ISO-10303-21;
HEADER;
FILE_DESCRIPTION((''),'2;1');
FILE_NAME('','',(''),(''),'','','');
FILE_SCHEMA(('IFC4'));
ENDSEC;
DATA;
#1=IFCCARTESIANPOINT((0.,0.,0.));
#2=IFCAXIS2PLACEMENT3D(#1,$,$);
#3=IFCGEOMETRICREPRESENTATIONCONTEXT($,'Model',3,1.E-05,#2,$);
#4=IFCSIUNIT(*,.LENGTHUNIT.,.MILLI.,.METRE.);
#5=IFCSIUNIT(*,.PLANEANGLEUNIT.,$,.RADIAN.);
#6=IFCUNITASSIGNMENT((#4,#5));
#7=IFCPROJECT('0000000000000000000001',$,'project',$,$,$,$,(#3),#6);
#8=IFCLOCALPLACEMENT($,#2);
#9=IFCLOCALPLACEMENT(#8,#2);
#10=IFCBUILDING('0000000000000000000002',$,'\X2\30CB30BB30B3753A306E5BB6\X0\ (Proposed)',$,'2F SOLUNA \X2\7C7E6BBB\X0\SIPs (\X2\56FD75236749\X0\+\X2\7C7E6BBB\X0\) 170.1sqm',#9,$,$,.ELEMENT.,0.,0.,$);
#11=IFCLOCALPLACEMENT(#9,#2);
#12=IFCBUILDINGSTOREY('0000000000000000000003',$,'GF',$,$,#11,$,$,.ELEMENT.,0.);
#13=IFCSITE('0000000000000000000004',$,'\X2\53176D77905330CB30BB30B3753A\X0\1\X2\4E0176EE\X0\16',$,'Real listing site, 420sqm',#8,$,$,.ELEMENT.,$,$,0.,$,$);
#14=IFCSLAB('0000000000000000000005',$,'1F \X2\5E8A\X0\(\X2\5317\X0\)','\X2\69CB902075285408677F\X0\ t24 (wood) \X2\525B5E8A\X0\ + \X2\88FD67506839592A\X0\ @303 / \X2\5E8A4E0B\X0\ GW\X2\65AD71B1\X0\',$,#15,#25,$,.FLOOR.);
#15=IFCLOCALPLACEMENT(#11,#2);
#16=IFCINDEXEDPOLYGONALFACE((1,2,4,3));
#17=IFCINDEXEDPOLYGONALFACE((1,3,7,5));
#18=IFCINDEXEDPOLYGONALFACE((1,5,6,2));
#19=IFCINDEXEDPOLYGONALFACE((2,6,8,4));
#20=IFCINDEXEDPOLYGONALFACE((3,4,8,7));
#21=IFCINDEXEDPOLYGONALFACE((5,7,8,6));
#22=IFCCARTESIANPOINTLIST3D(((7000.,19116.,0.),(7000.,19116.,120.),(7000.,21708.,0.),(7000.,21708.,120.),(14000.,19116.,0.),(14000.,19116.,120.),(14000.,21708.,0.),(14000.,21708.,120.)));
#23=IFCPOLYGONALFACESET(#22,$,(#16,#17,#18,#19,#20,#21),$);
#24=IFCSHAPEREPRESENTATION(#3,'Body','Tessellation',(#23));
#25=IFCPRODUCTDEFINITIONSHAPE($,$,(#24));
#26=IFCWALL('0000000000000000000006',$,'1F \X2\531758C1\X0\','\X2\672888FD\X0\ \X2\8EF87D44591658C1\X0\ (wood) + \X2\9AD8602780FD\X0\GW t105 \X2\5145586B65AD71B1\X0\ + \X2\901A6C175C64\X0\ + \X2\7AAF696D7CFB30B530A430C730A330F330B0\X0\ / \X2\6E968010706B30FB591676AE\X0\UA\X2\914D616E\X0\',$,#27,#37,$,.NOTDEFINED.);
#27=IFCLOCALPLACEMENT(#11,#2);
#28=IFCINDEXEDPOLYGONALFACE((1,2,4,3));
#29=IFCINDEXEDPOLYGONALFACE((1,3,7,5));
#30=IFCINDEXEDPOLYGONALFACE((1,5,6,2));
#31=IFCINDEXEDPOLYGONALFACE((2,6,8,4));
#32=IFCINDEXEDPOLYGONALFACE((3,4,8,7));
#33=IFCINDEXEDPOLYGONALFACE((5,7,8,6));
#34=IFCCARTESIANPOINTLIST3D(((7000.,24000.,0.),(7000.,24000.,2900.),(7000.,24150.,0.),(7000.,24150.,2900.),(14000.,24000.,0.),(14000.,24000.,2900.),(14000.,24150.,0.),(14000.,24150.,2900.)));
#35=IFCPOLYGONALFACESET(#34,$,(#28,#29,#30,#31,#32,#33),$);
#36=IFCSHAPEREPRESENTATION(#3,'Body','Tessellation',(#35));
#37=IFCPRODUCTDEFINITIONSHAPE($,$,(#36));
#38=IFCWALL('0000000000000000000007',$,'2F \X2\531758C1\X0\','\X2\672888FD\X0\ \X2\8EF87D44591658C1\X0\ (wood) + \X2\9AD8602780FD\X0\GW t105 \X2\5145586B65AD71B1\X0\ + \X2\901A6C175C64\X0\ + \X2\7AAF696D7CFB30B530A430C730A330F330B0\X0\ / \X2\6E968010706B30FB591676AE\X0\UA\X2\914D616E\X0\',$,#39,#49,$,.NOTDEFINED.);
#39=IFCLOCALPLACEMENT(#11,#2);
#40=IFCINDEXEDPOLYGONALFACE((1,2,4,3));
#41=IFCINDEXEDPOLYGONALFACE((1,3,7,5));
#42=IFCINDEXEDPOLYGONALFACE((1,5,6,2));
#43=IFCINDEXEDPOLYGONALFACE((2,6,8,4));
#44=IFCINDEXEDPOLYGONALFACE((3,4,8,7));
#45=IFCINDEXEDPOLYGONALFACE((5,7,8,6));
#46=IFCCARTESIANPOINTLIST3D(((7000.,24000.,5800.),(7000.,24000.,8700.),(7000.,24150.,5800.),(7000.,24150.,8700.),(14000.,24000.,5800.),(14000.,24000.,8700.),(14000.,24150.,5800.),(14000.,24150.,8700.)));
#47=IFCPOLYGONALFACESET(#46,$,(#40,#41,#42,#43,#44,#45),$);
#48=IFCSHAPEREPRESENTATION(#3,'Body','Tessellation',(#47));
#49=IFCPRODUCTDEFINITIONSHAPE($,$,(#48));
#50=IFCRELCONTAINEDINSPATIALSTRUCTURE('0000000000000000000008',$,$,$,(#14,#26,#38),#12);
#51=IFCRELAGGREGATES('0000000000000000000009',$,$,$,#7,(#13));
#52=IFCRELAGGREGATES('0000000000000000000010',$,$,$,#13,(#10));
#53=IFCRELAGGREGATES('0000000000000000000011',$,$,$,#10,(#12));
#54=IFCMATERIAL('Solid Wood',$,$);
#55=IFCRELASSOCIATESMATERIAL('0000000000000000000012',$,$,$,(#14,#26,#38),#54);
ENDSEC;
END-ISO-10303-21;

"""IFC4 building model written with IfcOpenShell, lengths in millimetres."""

from ifc_helpers import new_model, si_unit, frame, frame_2d, origin, place, context, project, spatial, rectangle, extrude, material, element, save


model = new_model("IFC4")

# Units and contexts
model_context = context("Model", 3, precision=1e-05, world=origin())
ifc_project = project(units=[si_unit("LENGTHUNIT", "METRE", prefix="MILLI"), si_unit("PLANEANGLEUNIT", "RADIAN")], contexts=[model_context])

# Site, building, storey
site_placement = place(None, origin())
site = spatial("IfcSite", under=ifc_project, at=site_placement, Name="北海道ニセコ町1丁目16", ObjectType="Real listing site, 420sqm", CompositionType="ELEMENT", RefElevation=0.0)
building_placement = place(site_placement, origin())
building = spatial("IfcBuilding", under=site, at=building_placement, Name="ニセコ町の家 (Proposed)", ObjectType="2F SOLUNA 籾殻SIPs (国産杉+籾殻) 170.1sqm", CompositionType="ELEMENT", ElevationOfRefHeight=0.0, ElevationOfTerrain=0.0)
storey_placement = place(building_placement, origin())
storey = spatial("IfcBuildingStorey", under=building, at=storey_placement, Name="GF", CompositionType="ELEMENT", Elevation=0.0)

# Slab
ifc_material_1 = material(Name="Solid Wood")
slab_1_placement = place(storey_placement, frame((3500.0, 9558.0, 0.0)))
element("IfcSlab", 1, at=slab_1_placement, inside=storey, material=ifc_material_1, Name="1F 床(北)", Description="構造用合板 t24 (wood) 剛床 + 製材根太 @303 / 床下 GW断熱", PredefinedType="FLOOR", context=model_context, shape_type="SweptSolid", body=[
    extrude(rectangle(XDim=7000.0, YDim=2592.0, at=frame_2d((3500.0, 1296.0))), frame((3500.0, 9558.0, 0.0)), (0.0, 0.0, 1.0), 120.0),
])

# Wall
wall_1_placement = place(storey_placement, frame((3500.0, 12000.0, 0.0)))
element("IfcWall", 2, at=wall_1_placement, inside=storey, material=ifc_material_1, Name="1F 北壁", Description="木製 軸組外壁 (wood) + 高性能GW t105 充填断熱 + 通気層 + 窯業系サイディング / 準耐火・外皮UA配慮", PredefinedType="NOTDEFINED", context=model_context, shape_type="SweptSolid", body=[
    extrude(rectangle(XDim=7000.0, YDim=150.0, at=frame_2d((3500.0, 75.0))), frame((3500.0, 12000.0, 0.0)), (0.0, 0.0, 1.0), 2900.0),
])

# Wall
wall_2_placement = place(storey_placement, frame((3500.0, 12000.0, 2900.0)))
element("IfcWall", 3, at=wall_2_placement, inside=storey, material=ifc_material_1, Name="2F 北壁", Description="木製 軸組外壁 (wood) + 高性能GW t105 充填断熱 + 通気層 + 窯業系サイディング / 準耐火・外皮UA配慮", PredefinedType="NOTDEFINED", context=model_context, shape_type="SweptSolid", body=[
    extrude(rectangle(XDim=7000.0, YDim=150.0, at=frame_2d((3500.0, 75.0))), frame((3500.0, 12000.0, 2900.0)), (0.0, 0.0, 1.0), 2900.0),
])

save(model, "model.ifc")
